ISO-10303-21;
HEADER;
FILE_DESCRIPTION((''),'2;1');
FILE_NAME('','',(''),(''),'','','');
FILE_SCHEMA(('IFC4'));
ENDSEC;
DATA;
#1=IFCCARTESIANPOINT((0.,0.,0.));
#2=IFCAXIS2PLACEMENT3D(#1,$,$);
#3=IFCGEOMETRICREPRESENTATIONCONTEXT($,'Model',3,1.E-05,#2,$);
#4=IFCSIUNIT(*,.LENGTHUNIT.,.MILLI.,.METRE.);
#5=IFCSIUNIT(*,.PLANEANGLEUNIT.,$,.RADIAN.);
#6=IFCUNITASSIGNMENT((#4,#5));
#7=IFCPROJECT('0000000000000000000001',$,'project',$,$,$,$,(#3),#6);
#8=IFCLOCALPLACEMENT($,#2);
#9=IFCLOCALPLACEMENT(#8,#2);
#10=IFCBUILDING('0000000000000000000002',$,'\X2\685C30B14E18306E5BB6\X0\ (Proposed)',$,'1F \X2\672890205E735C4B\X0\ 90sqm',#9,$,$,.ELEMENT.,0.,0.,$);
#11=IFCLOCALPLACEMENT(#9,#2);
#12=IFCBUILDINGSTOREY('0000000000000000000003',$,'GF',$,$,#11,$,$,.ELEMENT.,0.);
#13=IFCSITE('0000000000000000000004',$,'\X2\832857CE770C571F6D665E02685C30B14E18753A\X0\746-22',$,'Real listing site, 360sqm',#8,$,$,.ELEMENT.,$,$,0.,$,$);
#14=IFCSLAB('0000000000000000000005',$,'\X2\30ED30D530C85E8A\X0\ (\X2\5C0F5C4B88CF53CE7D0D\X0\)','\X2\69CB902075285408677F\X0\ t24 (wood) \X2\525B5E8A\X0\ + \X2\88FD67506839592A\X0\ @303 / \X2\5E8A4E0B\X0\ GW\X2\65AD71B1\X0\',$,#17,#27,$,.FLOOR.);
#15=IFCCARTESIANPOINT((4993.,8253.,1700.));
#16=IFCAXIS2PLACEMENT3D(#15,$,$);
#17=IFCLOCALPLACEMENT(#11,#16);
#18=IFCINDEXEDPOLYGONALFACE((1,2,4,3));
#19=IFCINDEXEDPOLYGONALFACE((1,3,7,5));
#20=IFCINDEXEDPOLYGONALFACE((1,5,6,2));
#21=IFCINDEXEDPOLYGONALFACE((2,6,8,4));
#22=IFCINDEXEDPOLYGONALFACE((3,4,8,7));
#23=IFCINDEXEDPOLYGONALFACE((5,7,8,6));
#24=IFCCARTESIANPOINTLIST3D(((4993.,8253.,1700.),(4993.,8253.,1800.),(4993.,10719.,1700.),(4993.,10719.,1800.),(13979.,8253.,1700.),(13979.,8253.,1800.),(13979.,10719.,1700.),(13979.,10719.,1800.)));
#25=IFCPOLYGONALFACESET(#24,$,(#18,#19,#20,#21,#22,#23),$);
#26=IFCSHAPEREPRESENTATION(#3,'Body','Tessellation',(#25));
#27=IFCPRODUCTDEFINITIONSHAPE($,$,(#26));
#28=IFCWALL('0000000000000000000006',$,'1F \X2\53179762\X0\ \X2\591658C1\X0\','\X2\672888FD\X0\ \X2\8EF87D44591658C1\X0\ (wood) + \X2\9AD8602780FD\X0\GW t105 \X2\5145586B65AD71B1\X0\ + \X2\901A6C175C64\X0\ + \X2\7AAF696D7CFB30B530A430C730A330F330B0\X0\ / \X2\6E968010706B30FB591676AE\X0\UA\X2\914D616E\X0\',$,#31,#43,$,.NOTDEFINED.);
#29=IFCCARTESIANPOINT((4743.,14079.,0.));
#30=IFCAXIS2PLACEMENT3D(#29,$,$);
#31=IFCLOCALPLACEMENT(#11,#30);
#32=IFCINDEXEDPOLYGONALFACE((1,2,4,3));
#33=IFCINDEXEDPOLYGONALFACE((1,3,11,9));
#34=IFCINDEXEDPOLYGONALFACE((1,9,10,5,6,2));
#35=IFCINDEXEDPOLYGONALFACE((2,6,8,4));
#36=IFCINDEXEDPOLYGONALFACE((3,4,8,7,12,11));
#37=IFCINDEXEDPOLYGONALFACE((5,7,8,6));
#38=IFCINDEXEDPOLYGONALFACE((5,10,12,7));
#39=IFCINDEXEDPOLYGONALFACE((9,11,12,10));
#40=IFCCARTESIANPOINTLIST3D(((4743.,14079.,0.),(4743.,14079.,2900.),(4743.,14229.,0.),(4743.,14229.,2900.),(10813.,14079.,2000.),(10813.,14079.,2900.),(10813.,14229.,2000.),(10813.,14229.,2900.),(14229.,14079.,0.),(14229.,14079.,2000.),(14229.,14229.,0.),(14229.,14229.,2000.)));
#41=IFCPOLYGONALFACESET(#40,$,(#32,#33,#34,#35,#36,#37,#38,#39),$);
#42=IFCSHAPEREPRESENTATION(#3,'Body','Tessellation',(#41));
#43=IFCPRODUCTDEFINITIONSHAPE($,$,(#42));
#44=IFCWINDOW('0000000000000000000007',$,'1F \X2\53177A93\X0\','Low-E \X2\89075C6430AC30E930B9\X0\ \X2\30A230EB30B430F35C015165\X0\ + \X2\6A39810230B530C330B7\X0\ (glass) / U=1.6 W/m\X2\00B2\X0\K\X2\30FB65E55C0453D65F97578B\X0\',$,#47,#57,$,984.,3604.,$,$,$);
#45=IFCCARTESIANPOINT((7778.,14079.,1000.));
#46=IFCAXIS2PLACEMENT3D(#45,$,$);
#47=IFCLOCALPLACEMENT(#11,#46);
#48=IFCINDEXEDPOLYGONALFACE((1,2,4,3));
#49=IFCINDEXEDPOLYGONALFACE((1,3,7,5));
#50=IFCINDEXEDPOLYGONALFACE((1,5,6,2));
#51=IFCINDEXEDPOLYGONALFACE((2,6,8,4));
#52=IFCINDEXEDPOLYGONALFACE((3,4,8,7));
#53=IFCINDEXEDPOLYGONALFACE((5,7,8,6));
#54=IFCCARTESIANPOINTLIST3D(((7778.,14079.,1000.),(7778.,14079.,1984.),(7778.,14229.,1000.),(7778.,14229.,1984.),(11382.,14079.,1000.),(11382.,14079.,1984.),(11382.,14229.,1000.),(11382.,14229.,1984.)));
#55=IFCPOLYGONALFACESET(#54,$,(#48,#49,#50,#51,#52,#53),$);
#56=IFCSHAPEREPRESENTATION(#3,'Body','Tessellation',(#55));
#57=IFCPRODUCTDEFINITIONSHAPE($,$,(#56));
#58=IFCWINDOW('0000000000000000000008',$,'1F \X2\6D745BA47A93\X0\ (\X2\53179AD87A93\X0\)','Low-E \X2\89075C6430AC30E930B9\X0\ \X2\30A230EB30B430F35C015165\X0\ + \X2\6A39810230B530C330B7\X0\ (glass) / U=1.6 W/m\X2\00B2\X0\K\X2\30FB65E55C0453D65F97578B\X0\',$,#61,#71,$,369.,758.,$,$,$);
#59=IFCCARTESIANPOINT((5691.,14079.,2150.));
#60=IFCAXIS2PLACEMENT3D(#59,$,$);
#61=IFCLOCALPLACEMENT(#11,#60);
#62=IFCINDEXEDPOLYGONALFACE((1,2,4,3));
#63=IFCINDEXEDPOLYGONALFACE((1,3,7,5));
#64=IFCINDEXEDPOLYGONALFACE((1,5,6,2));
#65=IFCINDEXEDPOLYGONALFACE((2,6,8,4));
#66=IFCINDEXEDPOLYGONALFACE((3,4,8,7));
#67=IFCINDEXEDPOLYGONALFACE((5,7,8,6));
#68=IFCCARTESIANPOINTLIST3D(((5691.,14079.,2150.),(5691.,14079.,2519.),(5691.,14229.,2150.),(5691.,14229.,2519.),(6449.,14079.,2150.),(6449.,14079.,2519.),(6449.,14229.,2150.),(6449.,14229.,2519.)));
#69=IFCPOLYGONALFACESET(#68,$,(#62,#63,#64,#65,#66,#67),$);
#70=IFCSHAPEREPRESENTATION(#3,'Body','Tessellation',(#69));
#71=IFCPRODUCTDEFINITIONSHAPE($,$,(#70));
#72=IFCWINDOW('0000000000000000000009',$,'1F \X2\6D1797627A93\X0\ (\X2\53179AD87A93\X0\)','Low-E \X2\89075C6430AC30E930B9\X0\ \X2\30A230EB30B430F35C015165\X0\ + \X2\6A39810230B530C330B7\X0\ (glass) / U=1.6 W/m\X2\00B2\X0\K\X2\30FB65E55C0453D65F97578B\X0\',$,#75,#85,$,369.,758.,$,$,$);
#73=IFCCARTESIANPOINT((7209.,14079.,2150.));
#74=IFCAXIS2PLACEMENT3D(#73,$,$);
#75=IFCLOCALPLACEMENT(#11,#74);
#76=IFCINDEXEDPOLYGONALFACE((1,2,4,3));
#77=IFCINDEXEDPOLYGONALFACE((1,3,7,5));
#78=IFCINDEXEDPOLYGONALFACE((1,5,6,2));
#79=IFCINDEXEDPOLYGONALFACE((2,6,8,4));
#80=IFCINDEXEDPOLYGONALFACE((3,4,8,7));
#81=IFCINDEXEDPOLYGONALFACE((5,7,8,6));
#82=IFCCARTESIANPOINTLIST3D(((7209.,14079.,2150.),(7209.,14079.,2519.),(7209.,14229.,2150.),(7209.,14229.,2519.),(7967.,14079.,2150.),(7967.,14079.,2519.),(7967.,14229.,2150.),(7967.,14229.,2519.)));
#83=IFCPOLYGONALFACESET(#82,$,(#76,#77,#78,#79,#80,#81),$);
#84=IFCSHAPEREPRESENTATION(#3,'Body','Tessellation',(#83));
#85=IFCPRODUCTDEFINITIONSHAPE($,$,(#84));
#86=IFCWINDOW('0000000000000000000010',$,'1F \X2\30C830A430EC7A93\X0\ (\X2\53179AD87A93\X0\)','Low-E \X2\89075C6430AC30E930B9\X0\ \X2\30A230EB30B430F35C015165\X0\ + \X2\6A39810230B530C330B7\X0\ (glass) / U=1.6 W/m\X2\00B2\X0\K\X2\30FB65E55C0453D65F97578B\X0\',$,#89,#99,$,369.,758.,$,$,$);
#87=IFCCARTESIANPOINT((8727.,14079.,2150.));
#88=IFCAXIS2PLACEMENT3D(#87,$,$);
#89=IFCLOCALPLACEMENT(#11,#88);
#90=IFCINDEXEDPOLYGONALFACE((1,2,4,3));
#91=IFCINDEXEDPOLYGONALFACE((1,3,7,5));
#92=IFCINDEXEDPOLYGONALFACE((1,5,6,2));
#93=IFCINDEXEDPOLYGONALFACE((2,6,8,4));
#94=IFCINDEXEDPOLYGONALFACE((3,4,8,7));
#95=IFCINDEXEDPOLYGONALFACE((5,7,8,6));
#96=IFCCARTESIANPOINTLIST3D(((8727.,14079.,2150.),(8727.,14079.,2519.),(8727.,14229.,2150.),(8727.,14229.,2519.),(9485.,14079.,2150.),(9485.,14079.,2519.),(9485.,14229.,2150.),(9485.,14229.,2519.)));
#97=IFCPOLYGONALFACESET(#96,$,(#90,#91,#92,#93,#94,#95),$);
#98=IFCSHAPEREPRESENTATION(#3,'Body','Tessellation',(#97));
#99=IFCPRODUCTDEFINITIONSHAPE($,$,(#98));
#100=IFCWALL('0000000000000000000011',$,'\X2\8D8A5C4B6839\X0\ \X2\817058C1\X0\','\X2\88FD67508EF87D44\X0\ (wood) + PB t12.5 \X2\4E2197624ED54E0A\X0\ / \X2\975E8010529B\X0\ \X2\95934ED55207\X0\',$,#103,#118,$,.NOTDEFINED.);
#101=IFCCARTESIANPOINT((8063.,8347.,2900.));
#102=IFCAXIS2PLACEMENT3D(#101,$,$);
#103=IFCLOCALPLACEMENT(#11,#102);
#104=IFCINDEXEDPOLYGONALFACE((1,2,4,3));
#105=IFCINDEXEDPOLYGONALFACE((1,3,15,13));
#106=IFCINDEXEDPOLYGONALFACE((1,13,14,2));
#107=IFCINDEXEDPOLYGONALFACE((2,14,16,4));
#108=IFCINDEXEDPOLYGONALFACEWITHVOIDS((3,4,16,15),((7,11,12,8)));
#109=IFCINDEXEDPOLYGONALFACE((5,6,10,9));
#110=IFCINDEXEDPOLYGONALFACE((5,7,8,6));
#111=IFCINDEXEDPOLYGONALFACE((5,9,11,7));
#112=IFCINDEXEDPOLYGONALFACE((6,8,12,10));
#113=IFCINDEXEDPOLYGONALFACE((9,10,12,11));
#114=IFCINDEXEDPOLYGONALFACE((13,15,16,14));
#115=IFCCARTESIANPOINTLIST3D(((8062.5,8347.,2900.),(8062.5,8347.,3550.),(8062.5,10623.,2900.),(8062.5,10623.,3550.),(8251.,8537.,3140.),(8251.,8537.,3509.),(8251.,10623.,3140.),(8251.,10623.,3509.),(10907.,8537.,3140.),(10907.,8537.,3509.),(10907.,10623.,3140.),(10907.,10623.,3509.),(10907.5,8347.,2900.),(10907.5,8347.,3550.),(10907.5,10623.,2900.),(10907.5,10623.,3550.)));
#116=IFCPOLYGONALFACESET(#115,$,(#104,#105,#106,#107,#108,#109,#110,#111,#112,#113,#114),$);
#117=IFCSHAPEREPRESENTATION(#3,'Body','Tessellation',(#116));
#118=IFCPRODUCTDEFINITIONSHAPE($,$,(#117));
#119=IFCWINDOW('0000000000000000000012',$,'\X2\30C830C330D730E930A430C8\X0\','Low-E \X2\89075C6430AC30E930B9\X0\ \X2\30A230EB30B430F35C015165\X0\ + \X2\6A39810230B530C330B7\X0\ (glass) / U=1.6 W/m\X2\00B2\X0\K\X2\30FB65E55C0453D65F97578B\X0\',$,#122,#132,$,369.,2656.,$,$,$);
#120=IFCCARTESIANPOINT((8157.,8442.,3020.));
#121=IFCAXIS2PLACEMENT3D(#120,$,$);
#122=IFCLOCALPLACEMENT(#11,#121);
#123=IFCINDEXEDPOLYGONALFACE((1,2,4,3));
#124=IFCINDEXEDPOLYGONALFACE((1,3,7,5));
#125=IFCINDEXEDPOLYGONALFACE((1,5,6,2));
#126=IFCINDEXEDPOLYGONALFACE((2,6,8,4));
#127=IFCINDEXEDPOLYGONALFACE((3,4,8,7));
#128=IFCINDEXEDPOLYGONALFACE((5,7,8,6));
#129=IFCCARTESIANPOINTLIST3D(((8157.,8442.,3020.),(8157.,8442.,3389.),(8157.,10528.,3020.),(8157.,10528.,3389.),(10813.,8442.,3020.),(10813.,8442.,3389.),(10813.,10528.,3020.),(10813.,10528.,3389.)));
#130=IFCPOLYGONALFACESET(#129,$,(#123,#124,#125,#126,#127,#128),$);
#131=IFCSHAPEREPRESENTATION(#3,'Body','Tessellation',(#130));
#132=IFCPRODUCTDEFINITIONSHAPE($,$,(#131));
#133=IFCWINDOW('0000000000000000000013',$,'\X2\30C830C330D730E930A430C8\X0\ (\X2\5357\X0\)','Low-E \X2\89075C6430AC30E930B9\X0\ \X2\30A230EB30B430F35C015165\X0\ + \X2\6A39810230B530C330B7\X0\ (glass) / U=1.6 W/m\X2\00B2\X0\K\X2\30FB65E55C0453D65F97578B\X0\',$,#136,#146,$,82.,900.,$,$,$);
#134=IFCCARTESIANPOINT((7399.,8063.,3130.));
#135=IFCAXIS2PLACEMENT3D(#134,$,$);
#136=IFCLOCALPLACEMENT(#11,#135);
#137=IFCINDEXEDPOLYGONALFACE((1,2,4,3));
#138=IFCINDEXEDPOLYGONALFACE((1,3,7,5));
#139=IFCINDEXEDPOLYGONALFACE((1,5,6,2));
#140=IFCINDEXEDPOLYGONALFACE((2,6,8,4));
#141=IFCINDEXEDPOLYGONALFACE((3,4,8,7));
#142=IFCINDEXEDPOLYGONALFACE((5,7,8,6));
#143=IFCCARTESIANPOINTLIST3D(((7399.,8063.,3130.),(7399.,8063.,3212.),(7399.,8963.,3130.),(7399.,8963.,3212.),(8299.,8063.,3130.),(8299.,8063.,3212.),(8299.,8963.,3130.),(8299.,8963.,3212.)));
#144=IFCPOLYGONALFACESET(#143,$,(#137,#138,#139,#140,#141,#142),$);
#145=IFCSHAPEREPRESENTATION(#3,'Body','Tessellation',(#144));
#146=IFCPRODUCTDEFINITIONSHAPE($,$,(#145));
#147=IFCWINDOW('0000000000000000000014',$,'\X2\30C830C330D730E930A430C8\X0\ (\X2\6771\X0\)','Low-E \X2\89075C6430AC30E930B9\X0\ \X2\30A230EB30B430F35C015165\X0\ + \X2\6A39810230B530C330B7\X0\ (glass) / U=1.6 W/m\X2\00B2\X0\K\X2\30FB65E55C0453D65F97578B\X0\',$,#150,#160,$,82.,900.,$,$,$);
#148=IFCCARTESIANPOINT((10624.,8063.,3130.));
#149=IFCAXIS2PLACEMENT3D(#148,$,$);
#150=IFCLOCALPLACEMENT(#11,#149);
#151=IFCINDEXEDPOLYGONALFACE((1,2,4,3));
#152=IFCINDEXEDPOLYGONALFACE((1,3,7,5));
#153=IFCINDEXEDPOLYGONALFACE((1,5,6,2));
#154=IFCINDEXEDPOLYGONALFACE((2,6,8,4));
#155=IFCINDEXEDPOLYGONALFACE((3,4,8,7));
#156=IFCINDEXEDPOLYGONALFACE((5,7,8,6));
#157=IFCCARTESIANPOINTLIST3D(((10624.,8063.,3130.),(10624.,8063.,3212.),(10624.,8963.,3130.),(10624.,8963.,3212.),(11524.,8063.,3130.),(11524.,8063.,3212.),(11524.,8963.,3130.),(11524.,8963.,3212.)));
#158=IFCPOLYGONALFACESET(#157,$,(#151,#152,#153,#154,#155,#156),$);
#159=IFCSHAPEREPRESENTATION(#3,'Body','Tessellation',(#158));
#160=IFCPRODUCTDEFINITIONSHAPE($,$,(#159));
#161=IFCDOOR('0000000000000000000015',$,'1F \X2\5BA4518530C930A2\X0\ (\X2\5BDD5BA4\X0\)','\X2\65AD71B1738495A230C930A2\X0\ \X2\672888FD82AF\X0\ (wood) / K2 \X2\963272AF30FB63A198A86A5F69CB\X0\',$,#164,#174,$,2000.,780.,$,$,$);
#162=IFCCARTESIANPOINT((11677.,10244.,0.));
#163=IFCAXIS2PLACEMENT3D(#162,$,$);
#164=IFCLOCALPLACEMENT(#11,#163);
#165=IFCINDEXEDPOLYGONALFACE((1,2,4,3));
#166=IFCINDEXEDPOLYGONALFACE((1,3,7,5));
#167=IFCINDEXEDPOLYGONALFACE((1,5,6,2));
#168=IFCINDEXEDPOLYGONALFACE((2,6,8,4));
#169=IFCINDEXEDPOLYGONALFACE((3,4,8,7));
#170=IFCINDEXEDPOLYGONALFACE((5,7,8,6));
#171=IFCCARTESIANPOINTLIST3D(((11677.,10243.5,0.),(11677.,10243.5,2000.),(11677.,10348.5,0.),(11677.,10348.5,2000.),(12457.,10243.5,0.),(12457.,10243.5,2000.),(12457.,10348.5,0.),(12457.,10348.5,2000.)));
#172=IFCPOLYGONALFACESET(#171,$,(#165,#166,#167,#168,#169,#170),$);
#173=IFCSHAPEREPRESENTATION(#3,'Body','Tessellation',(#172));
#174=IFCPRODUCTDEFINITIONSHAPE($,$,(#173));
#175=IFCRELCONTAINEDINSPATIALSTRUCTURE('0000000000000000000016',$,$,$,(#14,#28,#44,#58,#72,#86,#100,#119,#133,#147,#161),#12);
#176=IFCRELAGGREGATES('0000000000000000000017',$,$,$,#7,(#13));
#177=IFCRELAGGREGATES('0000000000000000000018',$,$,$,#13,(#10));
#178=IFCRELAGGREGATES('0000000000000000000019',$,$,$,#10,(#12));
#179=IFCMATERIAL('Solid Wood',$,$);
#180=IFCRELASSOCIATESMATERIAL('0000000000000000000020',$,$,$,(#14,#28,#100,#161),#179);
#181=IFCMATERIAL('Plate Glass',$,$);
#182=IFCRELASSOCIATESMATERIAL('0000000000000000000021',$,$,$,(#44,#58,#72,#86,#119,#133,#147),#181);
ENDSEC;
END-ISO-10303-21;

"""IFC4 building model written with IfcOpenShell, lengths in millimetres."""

from ifc_helpers import new_model, si_unit, frame, frame_2d, origin, place, context, project, spatial, rectangle, extrude, material, element, fill, save


model = new_model("IFC4")

# Units and contexts
model_context = context("Model", 3, precision=1e-05, world=origin())
ifc_project = project(units=[si_unit("LENGTHUNIT", "METRE", prefix="MILLI"), si_unit("PLANEANGLEUNIT", "RADIAN")], contexts=[model_context])

# Site, building, storey
site_placement = place(None, origin())
site = spatial("IfcSite", under=ifc_project, at=site_placement, Name="茨城県土浦市桜ケ丘町746-22", ObjectType="Real listing site, 360sqm", CompositionType="ELEMENT", RefElevation=0.0)
building_placement = place(site_placement, origin())
building = spatial("IfcBuilding", under=site, at=building_placement, Name="桜ケ丘の家 (Proposed)", ObjectType="1F 木造平屋 90sqm", CompositionType="ELEMENT", ElevationOfRefHeight=0.0, ElevationOfTerrain=0.0)
storey_placement = place(building_placement, origin())
storey = spatial("IfcBuildingStorey", under=building, at=storey_placement, Name="GF", CompositionType="ELEMENT", Elevation=0.0)

# Slab
ifc_material_1 = material(Name="Solid Wood")
slab_placement = place(storey_placement, frame((4993.0, 8253.0, 1700.0)))
element("IfcSlab", 1, at=slab_placement, inside=storey, material=ifc_material_1, Name="ロフト床 (小屋裏収納)", Description="構造用合板 t24 (wood) 剛床 + 製材根太 @303 / 床下 GW断熱", PredefinedType="FLOOR", context=model_context, shape_type="SweptSolid", body=[
    extrude(rectangle(XDim=8986.0, YDim=2466.0, at=frame_2d((4493.0, 1233.0))), frame((4993.0, 8253.0, 1700.0)), (0.0, 0.0, 1.0), 100.0),
])

# Wall, openings, windows
wall_1_placement = place(storey_placement, frame((4743.0, 14079.0, 0.0)))
wall_1 = element("IfcWall", 2, at=wall_1_placement, inside=storey, material=ifc_material_1, Name="1F 北面 外壁", Description="木製 軸組外壁 (wood) + 高性能GW t105 充填断熱 + 通気層 + 窯業系サイディング / 準耐火・外皮UA配慮", PredefinedType="NOTDEFINED", context=model_context, shape_type="SweptSolid", body=[
    extrude(rectangle(XDim=9486.0, YDim=150.0, at=frame_2d((4743.0, 75.0))), frame((4743.0, 14079.0, 0.0)), (0.0, 0.0, 1.0), 2900.0),
])
opening_1_placement = place(storey_placement, frame((7778.0, 14079.0, 1000.0)))
opening_1 = element("IfcOpeningElement", 3, at=opening_1_placement, cuts=wall_1, PredefinedType="NOTDEFINED", context=model_context, shape_type="SweptSolid", body=[
    extrude(rectangle(XDim=3604.0, YDim=150.0, at=frame_2d((1802.0, 75.0))), frame((7778.0, 14079.0, 1000.0)), (0.0, 0.0, 1.0), 984.0),
])
opening_2_placement = place(storey_placement, frame((5691.0, 14079.0, 2150.0)))
opening_2 = element("IfcOpeningElement", 4, at=opening_2_placement, cuts=wall_1, PredefinedType="NOTDEFINED", context=model_context, shape_type="SweptSolid", body=[
    extrude(rectangle(XDim=758.0, YDim=150.0, at=frame_2d((379.0, 75.0))), frame((5691.0, 14079.0, 2150.0)), (0.0, 0.0, 1.0), 369.0),
])
opening_3_placement = place(storey_placement, frame((7209.0, 14079.0, 2150.0)))
opening_3 = element("IfcOpeningElement", 5, at=opening_3_placement, cuts=wall_1, PredefinedType="NOTDEFINED", context=model_context, shape_type="SweptSolid", body=[
    extrude(rectangle(XDim=758.0, YDim=150.0, at=frame_2d((379.0, 75.0))), frame((7209.0, 14079.0, 2150.0)), (0.0, 0.0, 1.0), 369.0),
])
opening_4_placement = place(storey_placement, frame((8727.0, 14079.0, 2150.0)))
opening_4 = element("IfcOpeningElement", 6, at=opening_4_placement, cuts=wall_1, PredefinedType="NOTDEFINED", context=model_context, shape_type="SweptSolid", body=[
    extrude(rectangle(XDim=758.0, YDim=150.0, at=frame_2d((379.0, 75.0))), frame((8727.0, 14079.0, 2150.0)), (0.0, 0.0, 1.0), 369.0),
])
ifc_material_2 = material(Name="Plate Glass")
window_1_placement = place(storey_placement, frame((7778.0, 14079.0, 1000.0)))
window_1 = element("IfcWindow", 7, at=window_1_placement, inside=storey, material=ifc_material_2, Name="1F 北窓", Description="Low-E 複層ガラス アルゴン封入 + 樹脂サッシ (glass) / U=1.6 W/m²K・日射取得型", OverallHeight=984.0, OverallWidth=3604.0, context=model_context, shape_type="SweptSolid", body=[
    extrude(rectangle(XDim=3604.0, YDim=150.0, at=frame_2d((1802.0, 75.0))), frame((7778.0, 14079.0, 1000.0)), (0.0, 0.0, 1.0), 984.0),
])
fill(opening_1, window_1)
window_2_placement = place(storey_placement, frame((5691.0, 14079.0, 2150.0)))
window_2 = element("IfcWindow", 8, at=window_2_placement, inside=storey, material=ifc_material_2, Name="1F 浴室窓 (北高窓)", Description="Low-E 複層ガラス アルゴン封入 + 樹脂サッシ (glass) / U=1.6 W/m²K・日射取得型", OverallHeight=369.0, OverallWidth=758.0, context=model_context, shape_type="SweptSolid", body=[
    extrude(rectangle(XDim=758.0, YDim=150.0, at=frame_2d((379.0, 75.0))), frame((5691.0, 14079.0, 2150.0)), (0.0, 0.0, 1.0), 369.0),
])
fill(opening_2, window_2)
window_3_placement = place(storey_placement, frame((7209.0, 14079.0, 2150.0)))
window_3 = element("IfcWindow", 9, at=window_3_placement, inside=storey, material=ifc_material_2, Name="1F 洗面窓 (北高窓)", Description="Low-E 複層ガラス アルゴン封入 + 樹脂サッシ (glass) / U=1.6 W/m²K・日射取得型", OverallHeight=369.0, OverallWidth=758.0, context=model_context, shape_type="SweptSolid", body=[
    extrude(rectangle(XDim=758.0, YDim=150.0, at=frame_2d((379.0, 75.0))), frame((7209.0, 14079.0, 2150.0)), (0.0, 0.0, 1.0), 369.0),
])
fill(opening_3, window_3)
window_4_placement = place(storey_placement, frame((8727.0, 14079.0, 2150.0)))
window_4 = element("IfcWindow", 10, at=window_4_placement, inside=storey, material=ifc_material_2, Name="1F トイレ窓 (北高窓)", Description="Low-E 複層ガラス アルゴン封入 + 樹脂サッシ (glass) / U=1.6 W/m²K・日射取得型", OverallHeight=369.0, OverallWidth=758.0, context=model_context, shape_type="SweptSolid", body=[
    extrude(rectangle(XDim=758.0, YDim=150.0, at=frame_2d((379.0, 75.0))), frame((8727.0, 14079.0, 2150.0)), (0.0, 0.0, 1.0), 369.0),
])
fill(opening_4, window_4)

# Wall, openings, windows
wall_2_placement = place(storey_placement, frame((8063.0, 8347.0, 2900.0)))
wall_2 = element("IfcWall", 11, at=wall_2_placement, inside=storey, material=ifc_material_1, Name="越屋根 腰壁", Description="製材軸組 (wood) + PB t12.5 両面仕上 / 非耐力 間仕切", PredefinedType="NOTDEFINED", context=model_context, shape_type="SweptSolid", body=[
    extrude(rectangle(XDim=2845.0, YDim=2276.0, at=frame_2d((1422.0, 1138.0))), frame((8063.0, 8347.0, 2900.0)), (0.0, 0.0, 1.0), 650.0),
])
opening_5_placement = place(storey_placement, frame((8157.0, 8442.0, 3020.0)))
opening_5 = element("IfcOpeningElement", 12, at=opening_5_placement, cuts=wall_2, PredefinedType="NOTDEFINED", context=model_context, shape_type="SweptSolid", body=[
    extrude(rectangle(XDim=2656.0, YDim=2086.0, at=frame_2d((1328.0, 1043.0))), frame((8157.0, 8442.0, 3020.0)), (0.0, 0.0, 1.0), 369.0),
])
opening_6_placement = place(storey_placement, frame((7399.0, 8063.0, 3130.0)))
opening_6 = element("IfcOpeningElement", 13, at=opening_6_placement, cuts=wall_2, PredefinedType="NOTDEFINED", context=model_context, shape_type="SweptSolid", body=[
    extrude(rectangle(XDim=900.0, YDim=900.0, at=frame_2d((450.0, 450.0))), frame((7399.0, 8063.0, 3130.0)), (0.0, 0.0, 1.0), 82.0),
])
opening_7_placement = place(storey_placement, frame((10624.0, 8063.0, 3130.0)))
opening_7 = element("IfcOpeningElement", 14, at=opening_7_placement, cuts=wall_2, PredefinedType="NOTDEFINED", context=model_context, shape_type="SweptSolid", body=[
    extrude(rectangle(XDim=900.0, YDim=900.0, at=frame_2d((450.0, 450.0))), frame((10624.0, 8063.0, 3130.0)), (0.0, 0.0, 1.0), 82.0),
])
window_5_placement = place(storey_placement, frame((8157.0, 8442.0, 3020.0)))
window_5 = element("IfcWindow", 15, at=window_5_placement, inside=storey, material=ifc_material_2, Name="トップライト", Description="Low-E 複層ガラス アルゴン封入 + 樹脂サッシ (glass) / U=1.6 W/m²K・日射取得型", OverallHeight=369.0, OverallWidth=2656.0, context=model_context, shape_type="SweptSolid", body=[
    extrude(rectangle(XDim=2656.0, YDim=2086.0, at=frame_2d((1328.0, 1043.0))), frame((8157.0, 8442.0, 3020.0)), (0.0, 0.0, 1.0), 369.0),
])
fill(opening_5, window_5)
window_6_placement = place(storey_placement, frame((7399.0, 8063.0, 3130.0)))
window_6 = element("IfcWindow", 16, at=window_6_placement, inside=storey, material=ifc_material_2, Name="トップライト (南)", Description="Low-E 複層ガラス アルゴン封入 + 樹脂サッシ (glass) / U=1.6 W/m²K・日射取得型", OverallHeight=82.0, OverallWidth=900.0, context=model_context, shape_type="SweptSolid", body=[
    extrude(rectangle(XDim=900.0, YDim=900.0, at=frame_2d((450.0, 450.0))), frame((7399.0, 8063.0, 3130.0)), (0.0, 0.0, 1.0), 82.0),
])
fill(opening_6, window_6)
window_7_placement = place(storey_placement, frame((10624.0, 8063.0, 3130.0)))
window_7 = element("IfcWindow", 17, at=window_7_placement, inside=storey, material=ifc_material_2, Name="トップライト (東)", Description="Low-E 複層ガラス アルゴン封入 + 樹脂サッシ (glass) / U=1.6 W/m²K・日射取得型", OverallHeight=82.0, OverallWidth=900.0, context=model_context, shape_type="SweptSolid", body=[
    extrude(rectangle(XDim=900.0, YDim=900.0, at=frame_2d((450.0, 450.0))), frame((10624.0, 8063.0, 3130.0)), (0.0, 0.0, 1.0), 82.0),
])
fill(opening_7, window_7)

# Door
door_1_placement = place(storey_placement, frame((11677.0, 10244.0, 0.0)))
element("IfcDoor", 18, at=door_1_placement, inside=storey, material=ifc_material_1, Name="1F 室内ドア (寝室)", Description="断熱玄関ドア 木製芯 (wood) / K2 防犯・採風機構", OverallHeight=2000.0, OverallWidth=780.0, context=model_context, shape_type="SweptSolid", body=[
    extrude(rectangle(XDim=780.0, YDim=105.0, at=frame_2d((390.0, 52.0))), frame((11677.0, 10244.0, 0.0)), (0.0, 0.0, 1.0), 2000.0),
])

save(model, "model.ifc")
